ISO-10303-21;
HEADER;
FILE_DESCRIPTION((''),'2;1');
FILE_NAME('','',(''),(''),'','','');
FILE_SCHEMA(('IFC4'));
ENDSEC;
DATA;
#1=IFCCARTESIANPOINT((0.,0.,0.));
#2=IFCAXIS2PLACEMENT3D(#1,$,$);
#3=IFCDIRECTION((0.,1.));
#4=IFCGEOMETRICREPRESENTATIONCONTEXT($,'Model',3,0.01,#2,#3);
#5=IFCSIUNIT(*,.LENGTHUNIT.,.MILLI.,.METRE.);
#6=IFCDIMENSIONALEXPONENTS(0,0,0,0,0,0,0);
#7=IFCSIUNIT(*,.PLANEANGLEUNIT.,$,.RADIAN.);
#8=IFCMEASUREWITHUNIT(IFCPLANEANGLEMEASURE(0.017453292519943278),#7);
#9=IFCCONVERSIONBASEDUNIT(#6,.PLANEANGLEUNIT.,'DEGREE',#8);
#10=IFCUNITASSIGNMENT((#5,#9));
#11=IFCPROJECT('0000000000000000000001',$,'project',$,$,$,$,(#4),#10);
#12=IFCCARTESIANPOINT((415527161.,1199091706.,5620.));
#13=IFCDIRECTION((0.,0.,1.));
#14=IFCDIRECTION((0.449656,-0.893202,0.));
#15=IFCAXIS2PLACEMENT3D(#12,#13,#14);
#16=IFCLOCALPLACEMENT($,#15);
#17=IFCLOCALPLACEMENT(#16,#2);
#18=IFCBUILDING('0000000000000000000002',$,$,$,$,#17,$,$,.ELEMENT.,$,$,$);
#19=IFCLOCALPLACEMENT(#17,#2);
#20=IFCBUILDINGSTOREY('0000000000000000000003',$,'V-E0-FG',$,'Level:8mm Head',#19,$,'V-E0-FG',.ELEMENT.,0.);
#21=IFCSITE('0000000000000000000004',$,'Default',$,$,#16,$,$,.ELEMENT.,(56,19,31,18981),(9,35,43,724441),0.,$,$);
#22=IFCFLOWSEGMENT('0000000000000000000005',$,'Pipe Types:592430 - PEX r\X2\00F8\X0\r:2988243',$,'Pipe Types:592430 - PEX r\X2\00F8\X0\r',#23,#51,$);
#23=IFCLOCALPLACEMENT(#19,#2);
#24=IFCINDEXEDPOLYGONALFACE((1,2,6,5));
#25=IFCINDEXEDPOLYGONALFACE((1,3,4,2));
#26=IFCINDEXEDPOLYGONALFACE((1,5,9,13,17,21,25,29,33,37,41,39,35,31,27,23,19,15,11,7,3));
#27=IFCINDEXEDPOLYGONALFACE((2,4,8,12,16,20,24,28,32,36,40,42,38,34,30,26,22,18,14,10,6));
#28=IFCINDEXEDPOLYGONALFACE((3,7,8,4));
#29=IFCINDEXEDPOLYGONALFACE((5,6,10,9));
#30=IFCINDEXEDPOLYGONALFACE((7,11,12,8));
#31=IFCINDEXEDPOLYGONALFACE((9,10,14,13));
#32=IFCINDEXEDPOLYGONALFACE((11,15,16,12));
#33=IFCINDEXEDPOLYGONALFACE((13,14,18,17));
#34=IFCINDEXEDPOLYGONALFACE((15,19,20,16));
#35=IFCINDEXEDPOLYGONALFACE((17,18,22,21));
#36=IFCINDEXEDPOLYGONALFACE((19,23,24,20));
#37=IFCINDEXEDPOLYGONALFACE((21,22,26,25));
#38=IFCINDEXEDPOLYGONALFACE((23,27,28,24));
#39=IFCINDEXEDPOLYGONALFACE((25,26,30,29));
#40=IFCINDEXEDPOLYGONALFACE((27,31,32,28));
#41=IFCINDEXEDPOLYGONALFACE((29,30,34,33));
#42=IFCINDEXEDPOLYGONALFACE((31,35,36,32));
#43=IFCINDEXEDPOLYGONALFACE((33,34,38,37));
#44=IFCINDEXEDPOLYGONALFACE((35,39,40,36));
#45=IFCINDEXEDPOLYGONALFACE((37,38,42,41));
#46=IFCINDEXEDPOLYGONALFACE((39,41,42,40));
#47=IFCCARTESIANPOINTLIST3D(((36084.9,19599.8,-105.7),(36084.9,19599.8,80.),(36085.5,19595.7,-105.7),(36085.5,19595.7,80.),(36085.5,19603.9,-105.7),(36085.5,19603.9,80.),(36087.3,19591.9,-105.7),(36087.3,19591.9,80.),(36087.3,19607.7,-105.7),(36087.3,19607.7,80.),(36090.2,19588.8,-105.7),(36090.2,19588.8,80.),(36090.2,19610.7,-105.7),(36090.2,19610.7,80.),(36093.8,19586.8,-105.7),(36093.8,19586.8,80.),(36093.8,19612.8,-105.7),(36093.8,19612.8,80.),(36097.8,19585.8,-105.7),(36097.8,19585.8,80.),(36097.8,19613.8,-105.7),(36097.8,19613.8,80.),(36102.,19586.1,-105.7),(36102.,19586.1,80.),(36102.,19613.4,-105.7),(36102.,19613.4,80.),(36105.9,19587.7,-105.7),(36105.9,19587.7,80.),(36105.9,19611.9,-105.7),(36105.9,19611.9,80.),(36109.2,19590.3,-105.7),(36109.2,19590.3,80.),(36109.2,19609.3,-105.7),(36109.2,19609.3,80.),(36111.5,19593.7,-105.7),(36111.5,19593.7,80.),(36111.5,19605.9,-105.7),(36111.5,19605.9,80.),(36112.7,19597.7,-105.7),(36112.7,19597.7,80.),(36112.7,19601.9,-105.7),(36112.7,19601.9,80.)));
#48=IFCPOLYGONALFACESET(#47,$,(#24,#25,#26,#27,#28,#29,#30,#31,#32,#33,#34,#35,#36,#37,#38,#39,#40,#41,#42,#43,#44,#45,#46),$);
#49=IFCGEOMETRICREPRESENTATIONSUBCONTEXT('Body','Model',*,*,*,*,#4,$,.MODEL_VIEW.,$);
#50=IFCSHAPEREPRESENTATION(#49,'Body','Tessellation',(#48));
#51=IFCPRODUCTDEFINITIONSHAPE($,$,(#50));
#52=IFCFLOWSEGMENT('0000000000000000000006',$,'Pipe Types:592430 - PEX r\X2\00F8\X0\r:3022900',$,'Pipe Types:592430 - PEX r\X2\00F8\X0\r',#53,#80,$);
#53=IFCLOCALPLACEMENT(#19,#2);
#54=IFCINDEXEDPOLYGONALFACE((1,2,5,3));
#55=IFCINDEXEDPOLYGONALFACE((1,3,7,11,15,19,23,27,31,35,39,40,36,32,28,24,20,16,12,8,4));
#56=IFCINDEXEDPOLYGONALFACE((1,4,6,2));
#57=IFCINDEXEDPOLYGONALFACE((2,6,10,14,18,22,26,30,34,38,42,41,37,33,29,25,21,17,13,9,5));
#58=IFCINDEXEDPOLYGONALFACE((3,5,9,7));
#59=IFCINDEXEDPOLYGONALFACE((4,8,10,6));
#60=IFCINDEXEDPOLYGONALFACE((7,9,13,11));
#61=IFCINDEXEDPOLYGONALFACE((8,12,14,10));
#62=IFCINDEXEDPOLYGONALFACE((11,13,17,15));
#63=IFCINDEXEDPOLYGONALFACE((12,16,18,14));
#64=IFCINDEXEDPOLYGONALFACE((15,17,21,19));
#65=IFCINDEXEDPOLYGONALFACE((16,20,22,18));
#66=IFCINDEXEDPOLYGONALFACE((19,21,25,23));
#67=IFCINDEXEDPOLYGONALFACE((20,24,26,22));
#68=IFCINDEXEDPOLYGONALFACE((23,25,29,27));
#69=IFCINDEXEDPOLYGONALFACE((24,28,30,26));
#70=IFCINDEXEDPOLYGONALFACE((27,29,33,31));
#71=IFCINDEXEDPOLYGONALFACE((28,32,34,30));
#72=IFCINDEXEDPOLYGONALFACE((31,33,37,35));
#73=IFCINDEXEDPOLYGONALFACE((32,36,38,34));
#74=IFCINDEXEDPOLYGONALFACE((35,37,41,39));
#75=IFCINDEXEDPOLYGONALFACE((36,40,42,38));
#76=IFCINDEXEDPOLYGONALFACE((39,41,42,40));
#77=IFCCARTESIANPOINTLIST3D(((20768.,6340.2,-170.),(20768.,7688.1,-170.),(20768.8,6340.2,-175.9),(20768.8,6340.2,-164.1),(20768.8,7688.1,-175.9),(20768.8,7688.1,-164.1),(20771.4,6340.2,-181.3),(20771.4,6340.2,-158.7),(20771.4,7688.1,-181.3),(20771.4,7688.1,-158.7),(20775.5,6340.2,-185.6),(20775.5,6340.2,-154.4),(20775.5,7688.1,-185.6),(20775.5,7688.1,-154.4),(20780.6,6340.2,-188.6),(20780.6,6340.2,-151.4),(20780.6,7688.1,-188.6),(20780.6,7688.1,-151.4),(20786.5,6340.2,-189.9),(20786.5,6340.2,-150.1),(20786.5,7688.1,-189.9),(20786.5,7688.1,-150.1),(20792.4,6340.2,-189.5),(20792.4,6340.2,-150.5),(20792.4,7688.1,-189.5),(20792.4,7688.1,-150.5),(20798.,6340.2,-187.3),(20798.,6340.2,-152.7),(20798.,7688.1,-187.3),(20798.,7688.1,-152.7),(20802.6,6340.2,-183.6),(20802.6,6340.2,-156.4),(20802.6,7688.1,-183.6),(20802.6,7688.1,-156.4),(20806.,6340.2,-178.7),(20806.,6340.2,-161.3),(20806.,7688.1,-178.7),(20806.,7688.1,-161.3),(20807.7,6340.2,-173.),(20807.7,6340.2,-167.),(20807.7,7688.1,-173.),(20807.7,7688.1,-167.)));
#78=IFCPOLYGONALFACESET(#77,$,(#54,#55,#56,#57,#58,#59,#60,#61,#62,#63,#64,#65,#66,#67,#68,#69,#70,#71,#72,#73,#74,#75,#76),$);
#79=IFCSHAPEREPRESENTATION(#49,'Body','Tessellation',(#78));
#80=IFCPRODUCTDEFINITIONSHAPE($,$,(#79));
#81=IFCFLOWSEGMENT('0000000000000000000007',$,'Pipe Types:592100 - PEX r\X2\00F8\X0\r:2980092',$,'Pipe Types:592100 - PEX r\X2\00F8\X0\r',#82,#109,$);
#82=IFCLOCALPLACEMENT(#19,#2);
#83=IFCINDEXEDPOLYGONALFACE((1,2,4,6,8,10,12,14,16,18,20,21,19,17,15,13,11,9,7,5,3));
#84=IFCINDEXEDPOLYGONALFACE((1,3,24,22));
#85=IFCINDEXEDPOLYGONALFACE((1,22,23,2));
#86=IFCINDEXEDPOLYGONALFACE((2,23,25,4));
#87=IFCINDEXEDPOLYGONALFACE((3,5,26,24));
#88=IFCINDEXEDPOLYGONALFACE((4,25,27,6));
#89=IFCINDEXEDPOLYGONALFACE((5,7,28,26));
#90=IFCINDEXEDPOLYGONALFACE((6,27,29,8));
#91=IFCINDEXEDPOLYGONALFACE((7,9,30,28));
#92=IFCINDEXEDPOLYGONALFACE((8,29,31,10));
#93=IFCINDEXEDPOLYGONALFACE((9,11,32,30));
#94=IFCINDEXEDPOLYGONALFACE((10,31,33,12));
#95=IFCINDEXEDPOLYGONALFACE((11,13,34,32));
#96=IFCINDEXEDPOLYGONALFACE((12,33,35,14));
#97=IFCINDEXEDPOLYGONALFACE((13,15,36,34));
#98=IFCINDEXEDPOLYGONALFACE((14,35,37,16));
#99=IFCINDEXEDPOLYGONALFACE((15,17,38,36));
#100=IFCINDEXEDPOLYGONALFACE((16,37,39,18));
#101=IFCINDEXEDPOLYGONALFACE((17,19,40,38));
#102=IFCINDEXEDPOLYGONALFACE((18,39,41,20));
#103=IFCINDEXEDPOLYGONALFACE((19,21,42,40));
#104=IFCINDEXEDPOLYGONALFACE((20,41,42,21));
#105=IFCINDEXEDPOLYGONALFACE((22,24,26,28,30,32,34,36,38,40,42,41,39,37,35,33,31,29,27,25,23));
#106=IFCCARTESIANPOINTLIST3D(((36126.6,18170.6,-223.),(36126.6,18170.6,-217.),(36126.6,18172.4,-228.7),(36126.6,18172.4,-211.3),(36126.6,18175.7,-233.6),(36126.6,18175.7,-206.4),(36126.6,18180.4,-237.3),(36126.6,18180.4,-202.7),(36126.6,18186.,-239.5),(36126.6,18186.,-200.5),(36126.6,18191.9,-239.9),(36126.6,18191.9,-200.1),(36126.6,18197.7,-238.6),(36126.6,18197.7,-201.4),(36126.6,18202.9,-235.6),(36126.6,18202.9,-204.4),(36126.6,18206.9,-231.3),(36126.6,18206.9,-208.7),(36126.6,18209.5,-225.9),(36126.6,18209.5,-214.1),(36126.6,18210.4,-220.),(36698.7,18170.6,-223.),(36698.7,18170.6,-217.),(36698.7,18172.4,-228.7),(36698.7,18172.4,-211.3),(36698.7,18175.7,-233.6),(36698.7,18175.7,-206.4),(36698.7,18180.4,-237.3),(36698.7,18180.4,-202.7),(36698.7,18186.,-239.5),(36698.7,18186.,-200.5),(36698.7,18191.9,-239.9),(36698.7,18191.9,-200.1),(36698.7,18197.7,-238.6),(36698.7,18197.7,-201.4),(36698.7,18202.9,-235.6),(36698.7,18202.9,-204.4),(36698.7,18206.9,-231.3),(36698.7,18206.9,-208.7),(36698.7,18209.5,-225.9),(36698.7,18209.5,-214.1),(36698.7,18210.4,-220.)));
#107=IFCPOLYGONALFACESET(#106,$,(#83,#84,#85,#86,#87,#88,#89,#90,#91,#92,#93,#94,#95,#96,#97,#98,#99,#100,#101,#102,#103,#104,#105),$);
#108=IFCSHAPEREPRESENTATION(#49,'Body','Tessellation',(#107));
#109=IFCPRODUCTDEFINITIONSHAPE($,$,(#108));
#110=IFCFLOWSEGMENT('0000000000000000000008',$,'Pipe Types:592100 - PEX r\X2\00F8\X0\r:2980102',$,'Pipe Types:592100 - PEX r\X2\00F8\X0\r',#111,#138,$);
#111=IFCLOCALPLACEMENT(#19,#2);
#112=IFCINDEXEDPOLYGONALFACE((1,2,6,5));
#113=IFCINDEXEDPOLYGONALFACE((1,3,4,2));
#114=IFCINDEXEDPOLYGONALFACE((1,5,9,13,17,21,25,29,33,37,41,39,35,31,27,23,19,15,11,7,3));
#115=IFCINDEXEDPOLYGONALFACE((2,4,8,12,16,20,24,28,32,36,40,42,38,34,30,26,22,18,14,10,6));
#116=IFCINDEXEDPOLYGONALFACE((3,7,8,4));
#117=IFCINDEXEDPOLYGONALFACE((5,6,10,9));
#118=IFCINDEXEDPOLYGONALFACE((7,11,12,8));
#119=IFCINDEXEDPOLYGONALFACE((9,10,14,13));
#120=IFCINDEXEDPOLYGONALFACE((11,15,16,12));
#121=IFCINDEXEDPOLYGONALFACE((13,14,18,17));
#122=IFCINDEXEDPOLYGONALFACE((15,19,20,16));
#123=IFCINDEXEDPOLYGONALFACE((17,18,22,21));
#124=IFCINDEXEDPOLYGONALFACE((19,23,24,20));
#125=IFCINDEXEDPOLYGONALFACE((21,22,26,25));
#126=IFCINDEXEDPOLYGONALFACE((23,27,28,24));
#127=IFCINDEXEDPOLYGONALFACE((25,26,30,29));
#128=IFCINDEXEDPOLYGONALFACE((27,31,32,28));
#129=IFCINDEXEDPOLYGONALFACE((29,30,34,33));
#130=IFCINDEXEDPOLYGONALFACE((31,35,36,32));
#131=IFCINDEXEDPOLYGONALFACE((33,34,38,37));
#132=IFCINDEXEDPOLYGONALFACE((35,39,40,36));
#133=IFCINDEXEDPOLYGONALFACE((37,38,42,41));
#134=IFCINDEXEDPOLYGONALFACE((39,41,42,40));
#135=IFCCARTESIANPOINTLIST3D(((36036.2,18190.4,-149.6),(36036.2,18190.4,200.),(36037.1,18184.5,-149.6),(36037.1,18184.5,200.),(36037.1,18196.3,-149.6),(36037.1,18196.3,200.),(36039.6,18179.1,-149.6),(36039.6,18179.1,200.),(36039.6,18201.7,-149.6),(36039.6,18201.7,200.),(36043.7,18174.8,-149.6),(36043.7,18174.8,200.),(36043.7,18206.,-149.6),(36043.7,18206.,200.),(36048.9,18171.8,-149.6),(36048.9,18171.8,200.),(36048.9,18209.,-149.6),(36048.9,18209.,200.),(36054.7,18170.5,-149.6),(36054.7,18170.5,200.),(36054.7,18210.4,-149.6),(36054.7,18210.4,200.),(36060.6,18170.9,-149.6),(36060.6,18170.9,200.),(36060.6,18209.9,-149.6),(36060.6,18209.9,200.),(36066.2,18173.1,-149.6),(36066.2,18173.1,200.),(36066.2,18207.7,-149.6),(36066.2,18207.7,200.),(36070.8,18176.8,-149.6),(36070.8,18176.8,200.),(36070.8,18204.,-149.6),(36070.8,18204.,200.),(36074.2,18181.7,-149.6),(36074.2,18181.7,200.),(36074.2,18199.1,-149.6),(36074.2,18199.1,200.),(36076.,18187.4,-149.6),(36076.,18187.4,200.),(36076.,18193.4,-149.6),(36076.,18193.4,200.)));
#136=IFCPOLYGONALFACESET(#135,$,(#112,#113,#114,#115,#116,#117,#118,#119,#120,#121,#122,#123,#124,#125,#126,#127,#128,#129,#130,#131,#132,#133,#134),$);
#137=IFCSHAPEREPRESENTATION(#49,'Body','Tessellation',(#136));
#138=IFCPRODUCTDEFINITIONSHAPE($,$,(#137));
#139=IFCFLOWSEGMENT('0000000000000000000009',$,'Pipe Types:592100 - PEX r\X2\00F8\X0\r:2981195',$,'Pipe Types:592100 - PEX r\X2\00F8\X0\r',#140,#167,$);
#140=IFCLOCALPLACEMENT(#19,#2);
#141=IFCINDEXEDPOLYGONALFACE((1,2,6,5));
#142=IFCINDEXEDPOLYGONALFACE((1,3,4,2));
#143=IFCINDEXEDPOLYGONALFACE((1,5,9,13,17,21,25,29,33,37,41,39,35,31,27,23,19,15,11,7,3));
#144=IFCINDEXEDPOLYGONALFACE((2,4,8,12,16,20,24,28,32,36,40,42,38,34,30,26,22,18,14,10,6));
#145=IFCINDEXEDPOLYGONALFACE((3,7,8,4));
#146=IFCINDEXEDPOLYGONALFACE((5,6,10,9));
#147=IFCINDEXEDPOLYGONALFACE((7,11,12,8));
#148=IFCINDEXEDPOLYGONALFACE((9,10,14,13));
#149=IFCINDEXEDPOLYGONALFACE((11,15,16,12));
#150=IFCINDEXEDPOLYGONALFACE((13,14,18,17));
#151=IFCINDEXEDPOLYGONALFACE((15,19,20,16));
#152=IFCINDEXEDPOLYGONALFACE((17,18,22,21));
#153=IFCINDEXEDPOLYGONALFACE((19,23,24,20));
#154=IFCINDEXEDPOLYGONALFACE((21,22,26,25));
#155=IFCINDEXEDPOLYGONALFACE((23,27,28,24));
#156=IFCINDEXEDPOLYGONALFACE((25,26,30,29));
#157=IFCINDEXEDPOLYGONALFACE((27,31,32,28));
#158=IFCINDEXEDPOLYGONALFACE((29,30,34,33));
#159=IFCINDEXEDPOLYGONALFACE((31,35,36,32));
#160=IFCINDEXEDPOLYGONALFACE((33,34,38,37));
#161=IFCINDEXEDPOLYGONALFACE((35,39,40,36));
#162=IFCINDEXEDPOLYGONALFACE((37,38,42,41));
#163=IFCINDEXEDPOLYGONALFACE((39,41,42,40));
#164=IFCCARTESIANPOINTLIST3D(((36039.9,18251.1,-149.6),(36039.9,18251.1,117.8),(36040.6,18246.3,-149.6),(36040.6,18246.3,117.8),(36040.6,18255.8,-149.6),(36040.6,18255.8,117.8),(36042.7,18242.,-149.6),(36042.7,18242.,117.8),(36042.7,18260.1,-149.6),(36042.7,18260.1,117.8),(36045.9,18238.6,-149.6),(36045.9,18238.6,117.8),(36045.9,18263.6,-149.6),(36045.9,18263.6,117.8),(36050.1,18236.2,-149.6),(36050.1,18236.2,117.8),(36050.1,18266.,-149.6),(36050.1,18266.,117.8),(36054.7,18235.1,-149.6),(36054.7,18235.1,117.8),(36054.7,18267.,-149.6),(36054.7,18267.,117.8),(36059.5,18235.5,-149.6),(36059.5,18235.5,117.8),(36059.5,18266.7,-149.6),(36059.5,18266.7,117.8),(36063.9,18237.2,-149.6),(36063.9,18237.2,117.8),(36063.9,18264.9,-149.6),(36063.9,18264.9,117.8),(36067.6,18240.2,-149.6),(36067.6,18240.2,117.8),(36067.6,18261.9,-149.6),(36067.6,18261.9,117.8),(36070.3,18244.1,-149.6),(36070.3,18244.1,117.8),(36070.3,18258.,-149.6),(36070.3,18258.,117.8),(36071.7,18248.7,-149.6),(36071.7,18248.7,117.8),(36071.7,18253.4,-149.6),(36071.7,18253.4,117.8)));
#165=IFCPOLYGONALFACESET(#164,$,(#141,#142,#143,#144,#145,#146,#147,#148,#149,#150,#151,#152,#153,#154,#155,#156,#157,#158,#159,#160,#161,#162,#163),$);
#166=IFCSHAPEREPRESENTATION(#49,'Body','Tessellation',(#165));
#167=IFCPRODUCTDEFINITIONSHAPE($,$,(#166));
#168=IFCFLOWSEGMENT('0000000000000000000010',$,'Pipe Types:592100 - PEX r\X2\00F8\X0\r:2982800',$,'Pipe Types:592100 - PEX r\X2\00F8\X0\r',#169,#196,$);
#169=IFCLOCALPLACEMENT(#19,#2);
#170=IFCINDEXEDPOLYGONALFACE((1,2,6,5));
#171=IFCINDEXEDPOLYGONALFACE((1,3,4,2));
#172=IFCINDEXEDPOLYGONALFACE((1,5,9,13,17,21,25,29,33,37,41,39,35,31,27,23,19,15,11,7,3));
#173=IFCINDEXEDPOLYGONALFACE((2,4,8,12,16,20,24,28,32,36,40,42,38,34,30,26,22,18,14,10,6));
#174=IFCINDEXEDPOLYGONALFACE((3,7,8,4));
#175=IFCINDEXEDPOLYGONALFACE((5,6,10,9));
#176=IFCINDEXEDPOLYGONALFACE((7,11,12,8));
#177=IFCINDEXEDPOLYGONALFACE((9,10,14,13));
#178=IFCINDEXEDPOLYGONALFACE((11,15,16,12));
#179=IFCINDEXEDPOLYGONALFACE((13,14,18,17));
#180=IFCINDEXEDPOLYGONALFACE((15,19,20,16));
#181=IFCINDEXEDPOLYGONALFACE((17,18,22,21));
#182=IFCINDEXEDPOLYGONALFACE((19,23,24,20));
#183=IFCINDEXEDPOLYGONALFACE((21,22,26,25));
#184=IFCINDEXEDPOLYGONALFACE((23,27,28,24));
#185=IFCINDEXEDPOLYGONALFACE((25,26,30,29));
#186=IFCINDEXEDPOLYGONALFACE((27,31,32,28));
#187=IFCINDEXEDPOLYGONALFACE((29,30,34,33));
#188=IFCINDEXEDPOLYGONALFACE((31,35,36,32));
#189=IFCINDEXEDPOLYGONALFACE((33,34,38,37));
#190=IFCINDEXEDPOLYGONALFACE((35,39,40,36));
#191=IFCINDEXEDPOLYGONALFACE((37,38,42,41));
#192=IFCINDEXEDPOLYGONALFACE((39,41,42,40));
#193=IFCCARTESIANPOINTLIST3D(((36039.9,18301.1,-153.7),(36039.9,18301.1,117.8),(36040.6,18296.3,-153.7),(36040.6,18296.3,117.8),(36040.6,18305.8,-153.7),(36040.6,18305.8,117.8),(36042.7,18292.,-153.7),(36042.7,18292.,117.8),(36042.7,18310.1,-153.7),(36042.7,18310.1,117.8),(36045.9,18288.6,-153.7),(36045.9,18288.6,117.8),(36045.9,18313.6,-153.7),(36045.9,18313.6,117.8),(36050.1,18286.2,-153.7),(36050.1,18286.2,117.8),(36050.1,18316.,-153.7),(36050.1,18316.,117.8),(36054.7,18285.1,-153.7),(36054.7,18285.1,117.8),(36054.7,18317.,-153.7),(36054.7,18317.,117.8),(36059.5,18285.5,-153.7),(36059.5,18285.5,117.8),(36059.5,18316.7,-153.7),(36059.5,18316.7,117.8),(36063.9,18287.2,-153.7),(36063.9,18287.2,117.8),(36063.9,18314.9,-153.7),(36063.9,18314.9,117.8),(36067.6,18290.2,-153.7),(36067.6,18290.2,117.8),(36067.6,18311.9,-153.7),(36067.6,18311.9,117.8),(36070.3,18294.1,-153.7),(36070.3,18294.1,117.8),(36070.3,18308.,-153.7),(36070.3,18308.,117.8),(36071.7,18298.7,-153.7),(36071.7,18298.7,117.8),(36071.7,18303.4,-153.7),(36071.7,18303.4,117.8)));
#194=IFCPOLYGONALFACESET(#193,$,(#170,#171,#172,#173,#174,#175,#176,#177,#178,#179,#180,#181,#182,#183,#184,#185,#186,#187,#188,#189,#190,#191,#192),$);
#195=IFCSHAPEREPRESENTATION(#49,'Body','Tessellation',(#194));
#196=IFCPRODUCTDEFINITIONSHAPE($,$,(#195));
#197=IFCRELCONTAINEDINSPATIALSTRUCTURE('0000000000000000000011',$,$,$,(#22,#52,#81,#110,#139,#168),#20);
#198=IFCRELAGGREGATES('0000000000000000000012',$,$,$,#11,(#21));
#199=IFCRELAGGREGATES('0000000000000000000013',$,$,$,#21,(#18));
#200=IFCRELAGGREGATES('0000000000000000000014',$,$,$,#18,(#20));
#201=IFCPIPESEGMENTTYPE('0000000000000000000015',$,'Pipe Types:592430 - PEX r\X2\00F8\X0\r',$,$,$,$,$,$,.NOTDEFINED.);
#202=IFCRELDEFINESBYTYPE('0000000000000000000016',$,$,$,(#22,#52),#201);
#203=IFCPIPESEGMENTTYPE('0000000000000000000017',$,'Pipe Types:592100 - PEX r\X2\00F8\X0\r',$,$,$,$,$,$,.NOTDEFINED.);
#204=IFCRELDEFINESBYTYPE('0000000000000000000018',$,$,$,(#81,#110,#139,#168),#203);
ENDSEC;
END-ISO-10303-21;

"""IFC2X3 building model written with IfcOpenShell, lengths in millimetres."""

from ifc_helpers import new_model, entity, si_unit, converted_unit, direction, frame, frame_2d, origin, origin_2d_with_axis, place, context, subcontext, project, spatial, circle, extrude, type_object, element, save


model = new_model("IFC2X3")

# Units and contexts
model_context = context("Model", 3, precision=0.01, world=origin(), true_north=direction((0.0, 1.0)))
body_context = subcontext(model_context, "Body", "Model", "MODEL_VIEW")
ifc_project = project(units=[si_unit("LENGTHUNIT", "METRE", prefix="MILLI"), converted_unit("PLANEANGLEUNIT", "DEGREE", entity("IfcPlaneAngleMeasure", 0.017453292519943278), si_unit("PLANEANGLEUNIT", "RADIAN"), dimensions=[0, 0, 0, 0, 0, 0, 0])], contexts=[model_context])

# Site, building, storey
site_placement = place(None, frame((415527161.0, 1199091706.0, 5620.0), z_axis=(0.0, 0.0, 1.0), x_axis=(0.449656, -0.893202, 0.0)))
site = spatial("IfcSite", under=ifc_project, at=site_placement, Name="Default", CompositionType="ELEMENT", RefLatitude=(56, 19, 31, 18981), RefLongitude=(9, 35, 43, 724441), RefElevation=0.0)
building_placement = place(site_placement, origin())
building = spatial("IfcBuilding", under=site, at=building_placement, CompositionType="ELEMENT")
storey_placement = place(building_placement, origin())
storey = spatial("IfcBuildingStorey", under=building, at=storey_placement, Name="V-E0-FG", ObjectType="Level:8mm Head", LongName="V-E0-FG", CompositionType="ELEMENT", Elevation=0.0)

# Flow segments
pipe_segment_type_1 = type_object("IfcPipeSegmentType", Name="Pipe Types:592430 - PEX rør", PredefinedType="NOTDEFINED")
flow_segment_1_placement = place(storey_placement, origin())
element("IfcFlowSegment", 1, at=flow_segment_1_placement, inside=storey, type_object=pipe_segment_type_1, Name="Pipe Types:592430 - PEX rør:2988243", ObjectType="Pipe Types:592430 - PEX rør", context=body_context, shape_type="SweptSolid", body=[
    extrude(circle(Radius=14.0, at=frame_2d((0.0, 0.0), x_axis=(1.0, 0.0))), frame((36098.9, 19599.8, -105.7), z_axis=(0.0, 0.0, 1.0), x_axis=(-1.0, 0.0, 0.0)), (0.0, 0.0, 1.0), 185.7),
])
flow_segment_2_placement = place(storey_placement, origin())
element("IfcFlowSegment", 2, at=flow_segment_2_placement, inside=storey, type_object=pipe_segment_type_1, Name="Pipe Types:592430 - PEX rør:3022900", ObjectType="Pipe Types:592430 - PEX rør", context=body_context, shape_type="SweptSolid", body=[
    extrude(circle(Radius=20.0, at=origin_2d_with_axis()), frame((20788.0, 6340.2, -170.0), z_axis=(0.0, 1.0, 0.0), x_axis=(-1.0, 0.0, 0.0)), (0.0, 0.0, 1.0), 1347.9),
])
pipe_segment_type_2 = type_object("IfcPipeSegmentType", Name="Pipe Types:592100 - PEX rør", PredefinedType="NOTDEFINED")
flow_segment_3_placement = place(storey_placement, origin())
element("IfcFlowSegment", 3, at=flow_segment_3_placement, inside=storey, type_object=pipe_segment_type_2, Name="Pipe Types:592100 - PEX rør:2980092", ObjectType="Pipe Types:592100 - PEX rør", context=body_context, shape_type="SweptSolid", body=[
    extrude(circle(Radius=20.0, at=frame_2d((0.0, 0.0), x_axis=(1.0, 0.0))), frame((36126.6, 18190.4, -220.0), z_axis=(1.0, 0.0, 0.0), x_axis=(0.0, 1.0, 0.0)), (0.0, 0.0, 1.0), 572.1),
])
flow_segment_4_placement = place(storey_placement, origin())
element("IfcFlowSegment", 4, at=flow_segment_4_placement, inside=storey, type_object=pipe_segment_type_2, Name="Pipe Types:592100 - PEX rør:2980102", ObjectType="Pipe Types:592100 - PEX rør", context=body_context, shape_type="SweptSolid", body=[
    extrude(circle(Radius=20.0, at=origin_2d_with_axis()), frame((36056.2, 18190.4, -149.6), z_axis=(0.0, 0.0, 1.0), x_axis=(-1.0, 0.0, 0.0)), (0.0, 0.0, 1.0), 349.6),
])
flow_segment_5_placement = place(storey_placement, origin())
element("IfcFlowSegment", 5, at=flow_segment_5_placement, inside=storey, type_object=pipe_segment_type_2, Name="Pipe Types:592100 - PEX rør:2981195", ObjectType="Pipe Types:592100 - PEX rør", context=body_context, shape_type="SweptSolid", body=[
    extrude(circle(Radius=16.0, at=origin_2d_with_axis()), frame((36055.9, 18251.1, -149.6), z_axis=(0.0, 0.0, 1.0), x_axis=(-1.0, 0.0, 0.0)), (0.0, 0.0, 1.0), 267.4),
])
flow_segment_6_placement = place(storey_placement, origin())
element("IfcFlowSegment", 6, at=flow_segment_6_placement, inside=storey, type_object=pipe_segment_type_2, Name="Pipe Types:592100 - PEX rør:2982800", ObjectType="Pipe Types:592100 - PEX rør", context=body_context, shape_type="SweptSolid", body=[
    extrude(circle(Radius=16.0, at=origin_2d_with_axis()), frame((36055.9, 18301.1, -153.7), z_axis=(0.0, 0.0, 1.0), x_axis=(-1.0, 0.0, 0.0)), (0.0, 0.0, 1.0), 271.5),
])

save(model, "model.ifc")
